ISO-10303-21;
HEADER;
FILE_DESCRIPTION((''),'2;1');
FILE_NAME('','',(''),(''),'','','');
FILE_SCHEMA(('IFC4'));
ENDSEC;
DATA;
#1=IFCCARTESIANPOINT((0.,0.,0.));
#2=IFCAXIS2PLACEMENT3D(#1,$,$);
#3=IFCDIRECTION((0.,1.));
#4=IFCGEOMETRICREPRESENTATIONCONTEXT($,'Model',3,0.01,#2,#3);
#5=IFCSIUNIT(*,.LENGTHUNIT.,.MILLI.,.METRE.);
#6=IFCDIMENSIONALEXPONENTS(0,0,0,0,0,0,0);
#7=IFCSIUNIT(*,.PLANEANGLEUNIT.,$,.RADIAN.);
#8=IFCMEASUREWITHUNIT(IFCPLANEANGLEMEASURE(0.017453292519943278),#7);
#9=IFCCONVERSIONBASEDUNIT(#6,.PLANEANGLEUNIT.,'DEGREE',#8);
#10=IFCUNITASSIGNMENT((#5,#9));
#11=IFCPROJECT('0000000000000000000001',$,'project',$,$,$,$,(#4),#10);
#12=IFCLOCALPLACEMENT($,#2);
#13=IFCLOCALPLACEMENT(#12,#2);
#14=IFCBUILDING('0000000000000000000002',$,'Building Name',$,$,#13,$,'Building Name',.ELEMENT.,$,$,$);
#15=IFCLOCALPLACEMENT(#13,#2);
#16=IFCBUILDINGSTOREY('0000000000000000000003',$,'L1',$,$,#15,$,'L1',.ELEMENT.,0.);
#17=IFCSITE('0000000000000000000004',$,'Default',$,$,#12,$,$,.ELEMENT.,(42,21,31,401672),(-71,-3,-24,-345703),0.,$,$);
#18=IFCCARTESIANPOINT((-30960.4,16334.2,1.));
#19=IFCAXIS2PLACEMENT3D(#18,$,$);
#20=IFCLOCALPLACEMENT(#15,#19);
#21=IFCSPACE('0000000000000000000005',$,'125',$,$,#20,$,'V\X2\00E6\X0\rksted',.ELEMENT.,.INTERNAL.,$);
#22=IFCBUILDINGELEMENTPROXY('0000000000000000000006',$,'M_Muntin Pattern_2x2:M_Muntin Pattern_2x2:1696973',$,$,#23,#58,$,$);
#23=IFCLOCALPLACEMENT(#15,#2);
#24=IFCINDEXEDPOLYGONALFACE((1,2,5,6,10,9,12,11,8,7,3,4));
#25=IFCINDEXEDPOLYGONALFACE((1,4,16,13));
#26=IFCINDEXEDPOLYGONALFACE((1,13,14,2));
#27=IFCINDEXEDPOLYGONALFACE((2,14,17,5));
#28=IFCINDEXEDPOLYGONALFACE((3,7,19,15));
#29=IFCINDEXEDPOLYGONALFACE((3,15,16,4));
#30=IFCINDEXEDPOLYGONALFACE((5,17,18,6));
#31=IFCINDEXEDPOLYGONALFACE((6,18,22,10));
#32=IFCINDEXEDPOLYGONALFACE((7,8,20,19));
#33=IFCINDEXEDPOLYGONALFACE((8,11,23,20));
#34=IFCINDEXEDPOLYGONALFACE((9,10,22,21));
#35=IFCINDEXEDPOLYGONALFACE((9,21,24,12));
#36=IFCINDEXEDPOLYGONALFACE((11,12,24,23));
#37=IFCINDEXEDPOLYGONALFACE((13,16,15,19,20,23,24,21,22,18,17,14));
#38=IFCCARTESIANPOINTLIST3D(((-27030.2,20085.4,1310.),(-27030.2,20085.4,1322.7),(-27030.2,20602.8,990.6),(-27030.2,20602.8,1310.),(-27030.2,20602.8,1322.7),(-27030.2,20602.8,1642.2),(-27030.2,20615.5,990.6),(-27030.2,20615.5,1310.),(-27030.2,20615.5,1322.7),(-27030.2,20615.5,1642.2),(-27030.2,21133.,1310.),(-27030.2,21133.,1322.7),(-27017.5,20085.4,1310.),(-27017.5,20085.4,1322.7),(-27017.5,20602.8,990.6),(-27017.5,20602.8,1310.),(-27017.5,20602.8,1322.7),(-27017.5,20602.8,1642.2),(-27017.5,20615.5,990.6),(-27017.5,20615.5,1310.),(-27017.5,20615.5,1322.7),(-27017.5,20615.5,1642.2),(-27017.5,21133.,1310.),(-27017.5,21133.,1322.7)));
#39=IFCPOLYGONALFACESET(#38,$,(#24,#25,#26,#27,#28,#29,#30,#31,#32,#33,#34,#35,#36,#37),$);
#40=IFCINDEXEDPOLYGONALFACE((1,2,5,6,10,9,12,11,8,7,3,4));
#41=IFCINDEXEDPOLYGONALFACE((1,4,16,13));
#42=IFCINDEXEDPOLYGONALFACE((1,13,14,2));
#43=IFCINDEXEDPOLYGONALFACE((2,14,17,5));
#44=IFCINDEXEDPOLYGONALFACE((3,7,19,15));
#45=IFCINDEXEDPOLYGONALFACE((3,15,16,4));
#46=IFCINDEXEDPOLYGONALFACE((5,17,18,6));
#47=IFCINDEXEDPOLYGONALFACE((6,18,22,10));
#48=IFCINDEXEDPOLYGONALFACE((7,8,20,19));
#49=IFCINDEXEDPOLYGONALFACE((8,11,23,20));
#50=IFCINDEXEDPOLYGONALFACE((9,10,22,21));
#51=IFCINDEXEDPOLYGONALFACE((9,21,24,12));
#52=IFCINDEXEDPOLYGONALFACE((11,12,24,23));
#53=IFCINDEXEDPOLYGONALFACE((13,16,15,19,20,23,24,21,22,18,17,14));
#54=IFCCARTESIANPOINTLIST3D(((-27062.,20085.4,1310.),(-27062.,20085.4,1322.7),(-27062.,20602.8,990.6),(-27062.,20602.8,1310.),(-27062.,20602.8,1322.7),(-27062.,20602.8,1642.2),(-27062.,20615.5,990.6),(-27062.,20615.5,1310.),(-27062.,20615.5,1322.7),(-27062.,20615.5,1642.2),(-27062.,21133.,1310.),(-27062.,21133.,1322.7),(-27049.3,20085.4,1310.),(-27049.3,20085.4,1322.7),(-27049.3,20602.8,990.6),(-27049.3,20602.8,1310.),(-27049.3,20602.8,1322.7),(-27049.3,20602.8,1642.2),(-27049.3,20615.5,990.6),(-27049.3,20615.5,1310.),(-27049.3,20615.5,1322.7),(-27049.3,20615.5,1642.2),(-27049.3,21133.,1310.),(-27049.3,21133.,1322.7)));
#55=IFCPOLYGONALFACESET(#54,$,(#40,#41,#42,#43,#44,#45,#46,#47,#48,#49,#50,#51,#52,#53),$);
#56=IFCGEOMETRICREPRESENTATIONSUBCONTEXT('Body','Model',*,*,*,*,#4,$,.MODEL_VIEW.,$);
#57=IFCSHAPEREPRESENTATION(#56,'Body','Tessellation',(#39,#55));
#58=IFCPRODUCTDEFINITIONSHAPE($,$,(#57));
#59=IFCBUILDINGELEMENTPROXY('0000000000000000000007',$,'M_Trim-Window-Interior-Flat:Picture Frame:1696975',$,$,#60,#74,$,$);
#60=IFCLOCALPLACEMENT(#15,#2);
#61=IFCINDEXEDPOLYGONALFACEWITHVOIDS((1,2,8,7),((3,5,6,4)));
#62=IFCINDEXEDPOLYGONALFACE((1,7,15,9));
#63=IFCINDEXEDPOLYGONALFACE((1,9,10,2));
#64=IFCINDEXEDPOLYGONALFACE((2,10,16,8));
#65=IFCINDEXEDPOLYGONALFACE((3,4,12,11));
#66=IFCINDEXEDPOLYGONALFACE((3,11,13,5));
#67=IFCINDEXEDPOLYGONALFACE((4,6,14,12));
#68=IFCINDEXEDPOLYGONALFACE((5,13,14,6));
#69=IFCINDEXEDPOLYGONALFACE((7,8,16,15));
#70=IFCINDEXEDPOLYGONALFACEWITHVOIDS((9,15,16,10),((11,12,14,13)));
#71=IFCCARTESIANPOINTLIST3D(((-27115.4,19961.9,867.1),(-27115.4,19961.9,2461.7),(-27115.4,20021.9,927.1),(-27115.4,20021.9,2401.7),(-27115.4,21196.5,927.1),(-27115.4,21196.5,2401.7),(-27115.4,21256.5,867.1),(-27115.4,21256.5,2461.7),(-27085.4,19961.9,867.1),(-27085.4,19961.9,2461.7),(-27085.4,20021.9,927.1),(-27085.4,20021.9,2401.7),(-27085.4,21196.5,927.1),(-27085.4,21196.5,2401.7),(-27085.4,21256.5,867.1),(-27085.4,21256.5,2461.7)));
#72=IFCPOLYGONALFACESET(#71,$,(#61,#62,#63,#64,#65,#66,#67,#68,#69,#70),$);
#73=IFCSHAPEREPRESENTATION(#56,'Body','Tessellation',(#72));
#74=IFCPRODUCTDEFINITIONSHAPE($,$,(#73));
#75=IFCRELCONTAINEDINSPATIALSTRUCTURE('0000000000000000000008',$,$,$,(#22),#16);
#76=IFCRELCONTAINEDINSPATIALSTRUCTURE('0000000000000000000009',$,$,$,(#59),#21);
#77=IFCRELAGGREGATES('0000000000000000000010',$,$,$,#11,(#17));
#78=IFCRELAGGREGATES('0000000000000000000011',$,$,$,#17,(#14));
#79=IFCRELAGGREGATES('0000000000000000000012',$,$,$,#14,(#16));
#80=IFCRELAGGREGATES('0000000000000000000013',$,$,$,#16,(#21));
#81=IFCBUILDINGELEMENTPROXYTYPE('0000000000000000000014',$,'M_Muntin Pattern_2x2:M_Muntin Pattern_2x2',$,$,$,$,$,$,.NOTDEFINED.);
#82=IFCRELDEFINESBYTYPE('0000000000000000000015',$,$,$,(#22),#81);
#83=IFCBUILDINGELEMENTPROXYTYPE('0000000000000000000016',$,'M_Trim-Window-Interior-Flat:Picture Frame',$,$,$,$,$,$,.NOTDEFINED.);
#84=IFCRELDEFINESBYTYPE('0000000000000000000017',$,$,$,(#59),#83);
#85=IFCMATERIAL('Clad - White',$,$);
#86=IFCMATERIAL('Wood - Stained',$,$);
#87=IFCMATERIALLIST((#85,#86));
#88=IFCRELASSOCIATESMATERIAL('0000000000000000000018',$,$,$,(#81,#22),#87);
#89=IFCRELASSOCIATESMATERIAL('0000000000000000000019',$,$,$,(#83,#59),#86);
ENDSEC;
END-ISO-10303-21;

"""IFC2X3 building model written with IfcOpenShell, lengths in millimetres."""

from ifc_helpers import new_model, entity, si_unit, converted_unit, direction, frame, origin, place, context, subcontext, project, spatial, polyline, outline, extrude, source, transform, mapped, material, material_list, type_object, type_shapes, element, save


model = new_model("IFC2X3")

# Units and contexts
model_context = context("Model", 3, precision=0.01, world=origin(), true_north=direction((0.0, 1.0)))
body_context = subcontext(model_context, "Body", "Model", "MODEL_VIEW")
ifc_project = project(units=[si_unit("LENGTHUNIT", "METRE", prefix="MILLI"), converted_unit("PLANEANGLEUNIT", "DEGREE", entity("IfcPlaneAngleMeasure", 0.017453292519943278), si_unit("PLANEANGLEUNIT", "RADIAN"), dimensions=[0, 0, 0, 0, 0, 0, 0])], contexts=[model_context])

# Site, building, storey
site_placement = place(None, origin())
site = spatial("IfcSite", under=ifc_project, at=site_placement, Name="Default", CompositionType="ELEMENT", RefLatitude=(42, 21, 31, 401672), RefLongitude=(-71, -3, -24, -345703), RefElevation=0.0)
building_placement = place(site_placement, origin())
building = spatial("IfcBuilding", under=site, at=building_placement, Name="Building Name", LongName="Building Name", CompositionType="ELEMENT")
storey_placement = place(building_placement, origin())
storey = spatial("IfcBuildingStorey", under=building, at=storey_placement, Name="L1", LongName="L1", CompositionType="ELEMENT", Elevation=0.0)

# Shared definitions
ifc_material_1 = material(Name="Wood - Stained")

# Shared definitions
ifc_material_2 = material(Name="Clad - White")
ifc_material_list_1 = material_list([ifc_material_2, ifc_material_1])

# Shared definitions
space_placement = place(storey_placement, frame((-30960.4, 16334.2, 1.0)))
space = spatial("IfcSpace", under=storey, at=space_placement, Name="125", LongName="Værksted", CompositionType="ELEMENT", InteriorOrExteriorSpace="INTERNAL")

# Building element proxies
building_element_proxy_type_1 = type_object("IfcBuildingElementProxyType", Name="M_Muntin Pattern_2x2:M_Muntin Pattern_2x2", PredefinedType="NOTDEFINED", material=ifc_material_list_1)
shared_shape_1 = source(origin(), body_context, "Body", "SweptSolid", [
    extrude(outline(polyline([(6.4, -6.4), (325.8, -6.4), (325.8, 6.3), (6.4, 6.3), (6.4, 523.8), (-6.3, 523.8), (-6.3, 6.3), (-325.8, 6.3), (-325.8, -6.4), (-6.3, -6.4), (-6.3, -523.8), (6.4, -523.8), (6.4, -6.4)])), frame((0.0, -22.2, 325.8), z_axis=(0.0, 1.0, 0.0), x_axis=(0.0, 0.0, 1.0)), (0.0, 0.0, 1.0), 12.7),
    extrude(outline(polyline([(6.4, -6.4), (325.8, -6.4), (325.8, 6.3), (6.4, 6.3), (6.4, 523.8), (-6.3, 523.8), (-6.3, 6.3), (-325.8, 6.3), (-325.8, -6.4), (-6.3, -6.4), (-6.3, -523.8), (6.4, -523.8), (6.4, -6.4)])), frame((0.0, 9.5, 325.8), z_axis=(0.0, 1.0, 0.0), x_axis=(0.0, 0.0, 1.0)), (0.0, 0.0, 1.0), 12.7),
])
type_shapes(building_element_proxy_type_1, [shared_shape_1])
proxy_1_placement = place(storey_placement, frame((-27039.7, 20609.2, 990.6), z_axis=(0.0, 0.0, 1.0), x_axis=(0.0, 1.0, 0.0)))
element("IfcBuildingElementProxy", 1, at=proxy_1_placement, inside=storey, type_object=building_element_proxy_type_1, material=ifc_material_list_1, Name="M_Muntin Pattern_2x2:M_Muntin Pattern_2x2:1696973", context=body_context, shape_type="MappedRepresentation", body=[
    mapped(shared_shape_1, transform((0.0, 0.0, 0.0), scale=1.0)),
])
building_element_proxy_type_2 = type_object("IfcBuildingElementProxyType", Name="M_Trim-Window-Interior-Flat:Picture Frame", PredefinedType="NOTDEFINED", material=ifc_material_1)
shared_shape_2 = source(origin(), body_context, "Body", "SweptSolid", [
    extrude(outline(polyline([(-797.3, -647.3), (797.3, -647.3), (797.3, 647.3), (-797.3, 647.3), (-797.3, -647.3)]), holes=[polyline([(-737.3, -587.3), (-737.3, 587.3), (737.3, 587.3), (737.3, -587.3), (-737.3, -587.3)])]), frame((0.0, 750.0, 0.0), z_axis=(0.0, 0.0, 1.0), x_axis=(0.0, 1.0, 0.0)), (0.0, 0.0, 1.0), 30.0),
])
type_shapes(building_element_proxy_type_2, [shared_shape_2])
proxy_2_placement = place(space_placement, frame((3875.0, 4275.0, 2413.4), z_axis=(-1.0, 0.0, 0.0), x_axis=(0.0, 1.0, 0.0)))
element("IfcBuildingElementProxy", 2, at=proxy_2_placement, inside=space, type_object=building_element_proxy_type_2, material=ifc_material_1, Name="M_Trim-Window-Interior-Flat:Picture Frame:1696975", context=body_context, shape_type="MappedRepresentation", body=[
    mapped(shared_shape_2, transform((0.0, 0.0, 0.0), scale=1.0)),
])

save(model, "model.ifc")
